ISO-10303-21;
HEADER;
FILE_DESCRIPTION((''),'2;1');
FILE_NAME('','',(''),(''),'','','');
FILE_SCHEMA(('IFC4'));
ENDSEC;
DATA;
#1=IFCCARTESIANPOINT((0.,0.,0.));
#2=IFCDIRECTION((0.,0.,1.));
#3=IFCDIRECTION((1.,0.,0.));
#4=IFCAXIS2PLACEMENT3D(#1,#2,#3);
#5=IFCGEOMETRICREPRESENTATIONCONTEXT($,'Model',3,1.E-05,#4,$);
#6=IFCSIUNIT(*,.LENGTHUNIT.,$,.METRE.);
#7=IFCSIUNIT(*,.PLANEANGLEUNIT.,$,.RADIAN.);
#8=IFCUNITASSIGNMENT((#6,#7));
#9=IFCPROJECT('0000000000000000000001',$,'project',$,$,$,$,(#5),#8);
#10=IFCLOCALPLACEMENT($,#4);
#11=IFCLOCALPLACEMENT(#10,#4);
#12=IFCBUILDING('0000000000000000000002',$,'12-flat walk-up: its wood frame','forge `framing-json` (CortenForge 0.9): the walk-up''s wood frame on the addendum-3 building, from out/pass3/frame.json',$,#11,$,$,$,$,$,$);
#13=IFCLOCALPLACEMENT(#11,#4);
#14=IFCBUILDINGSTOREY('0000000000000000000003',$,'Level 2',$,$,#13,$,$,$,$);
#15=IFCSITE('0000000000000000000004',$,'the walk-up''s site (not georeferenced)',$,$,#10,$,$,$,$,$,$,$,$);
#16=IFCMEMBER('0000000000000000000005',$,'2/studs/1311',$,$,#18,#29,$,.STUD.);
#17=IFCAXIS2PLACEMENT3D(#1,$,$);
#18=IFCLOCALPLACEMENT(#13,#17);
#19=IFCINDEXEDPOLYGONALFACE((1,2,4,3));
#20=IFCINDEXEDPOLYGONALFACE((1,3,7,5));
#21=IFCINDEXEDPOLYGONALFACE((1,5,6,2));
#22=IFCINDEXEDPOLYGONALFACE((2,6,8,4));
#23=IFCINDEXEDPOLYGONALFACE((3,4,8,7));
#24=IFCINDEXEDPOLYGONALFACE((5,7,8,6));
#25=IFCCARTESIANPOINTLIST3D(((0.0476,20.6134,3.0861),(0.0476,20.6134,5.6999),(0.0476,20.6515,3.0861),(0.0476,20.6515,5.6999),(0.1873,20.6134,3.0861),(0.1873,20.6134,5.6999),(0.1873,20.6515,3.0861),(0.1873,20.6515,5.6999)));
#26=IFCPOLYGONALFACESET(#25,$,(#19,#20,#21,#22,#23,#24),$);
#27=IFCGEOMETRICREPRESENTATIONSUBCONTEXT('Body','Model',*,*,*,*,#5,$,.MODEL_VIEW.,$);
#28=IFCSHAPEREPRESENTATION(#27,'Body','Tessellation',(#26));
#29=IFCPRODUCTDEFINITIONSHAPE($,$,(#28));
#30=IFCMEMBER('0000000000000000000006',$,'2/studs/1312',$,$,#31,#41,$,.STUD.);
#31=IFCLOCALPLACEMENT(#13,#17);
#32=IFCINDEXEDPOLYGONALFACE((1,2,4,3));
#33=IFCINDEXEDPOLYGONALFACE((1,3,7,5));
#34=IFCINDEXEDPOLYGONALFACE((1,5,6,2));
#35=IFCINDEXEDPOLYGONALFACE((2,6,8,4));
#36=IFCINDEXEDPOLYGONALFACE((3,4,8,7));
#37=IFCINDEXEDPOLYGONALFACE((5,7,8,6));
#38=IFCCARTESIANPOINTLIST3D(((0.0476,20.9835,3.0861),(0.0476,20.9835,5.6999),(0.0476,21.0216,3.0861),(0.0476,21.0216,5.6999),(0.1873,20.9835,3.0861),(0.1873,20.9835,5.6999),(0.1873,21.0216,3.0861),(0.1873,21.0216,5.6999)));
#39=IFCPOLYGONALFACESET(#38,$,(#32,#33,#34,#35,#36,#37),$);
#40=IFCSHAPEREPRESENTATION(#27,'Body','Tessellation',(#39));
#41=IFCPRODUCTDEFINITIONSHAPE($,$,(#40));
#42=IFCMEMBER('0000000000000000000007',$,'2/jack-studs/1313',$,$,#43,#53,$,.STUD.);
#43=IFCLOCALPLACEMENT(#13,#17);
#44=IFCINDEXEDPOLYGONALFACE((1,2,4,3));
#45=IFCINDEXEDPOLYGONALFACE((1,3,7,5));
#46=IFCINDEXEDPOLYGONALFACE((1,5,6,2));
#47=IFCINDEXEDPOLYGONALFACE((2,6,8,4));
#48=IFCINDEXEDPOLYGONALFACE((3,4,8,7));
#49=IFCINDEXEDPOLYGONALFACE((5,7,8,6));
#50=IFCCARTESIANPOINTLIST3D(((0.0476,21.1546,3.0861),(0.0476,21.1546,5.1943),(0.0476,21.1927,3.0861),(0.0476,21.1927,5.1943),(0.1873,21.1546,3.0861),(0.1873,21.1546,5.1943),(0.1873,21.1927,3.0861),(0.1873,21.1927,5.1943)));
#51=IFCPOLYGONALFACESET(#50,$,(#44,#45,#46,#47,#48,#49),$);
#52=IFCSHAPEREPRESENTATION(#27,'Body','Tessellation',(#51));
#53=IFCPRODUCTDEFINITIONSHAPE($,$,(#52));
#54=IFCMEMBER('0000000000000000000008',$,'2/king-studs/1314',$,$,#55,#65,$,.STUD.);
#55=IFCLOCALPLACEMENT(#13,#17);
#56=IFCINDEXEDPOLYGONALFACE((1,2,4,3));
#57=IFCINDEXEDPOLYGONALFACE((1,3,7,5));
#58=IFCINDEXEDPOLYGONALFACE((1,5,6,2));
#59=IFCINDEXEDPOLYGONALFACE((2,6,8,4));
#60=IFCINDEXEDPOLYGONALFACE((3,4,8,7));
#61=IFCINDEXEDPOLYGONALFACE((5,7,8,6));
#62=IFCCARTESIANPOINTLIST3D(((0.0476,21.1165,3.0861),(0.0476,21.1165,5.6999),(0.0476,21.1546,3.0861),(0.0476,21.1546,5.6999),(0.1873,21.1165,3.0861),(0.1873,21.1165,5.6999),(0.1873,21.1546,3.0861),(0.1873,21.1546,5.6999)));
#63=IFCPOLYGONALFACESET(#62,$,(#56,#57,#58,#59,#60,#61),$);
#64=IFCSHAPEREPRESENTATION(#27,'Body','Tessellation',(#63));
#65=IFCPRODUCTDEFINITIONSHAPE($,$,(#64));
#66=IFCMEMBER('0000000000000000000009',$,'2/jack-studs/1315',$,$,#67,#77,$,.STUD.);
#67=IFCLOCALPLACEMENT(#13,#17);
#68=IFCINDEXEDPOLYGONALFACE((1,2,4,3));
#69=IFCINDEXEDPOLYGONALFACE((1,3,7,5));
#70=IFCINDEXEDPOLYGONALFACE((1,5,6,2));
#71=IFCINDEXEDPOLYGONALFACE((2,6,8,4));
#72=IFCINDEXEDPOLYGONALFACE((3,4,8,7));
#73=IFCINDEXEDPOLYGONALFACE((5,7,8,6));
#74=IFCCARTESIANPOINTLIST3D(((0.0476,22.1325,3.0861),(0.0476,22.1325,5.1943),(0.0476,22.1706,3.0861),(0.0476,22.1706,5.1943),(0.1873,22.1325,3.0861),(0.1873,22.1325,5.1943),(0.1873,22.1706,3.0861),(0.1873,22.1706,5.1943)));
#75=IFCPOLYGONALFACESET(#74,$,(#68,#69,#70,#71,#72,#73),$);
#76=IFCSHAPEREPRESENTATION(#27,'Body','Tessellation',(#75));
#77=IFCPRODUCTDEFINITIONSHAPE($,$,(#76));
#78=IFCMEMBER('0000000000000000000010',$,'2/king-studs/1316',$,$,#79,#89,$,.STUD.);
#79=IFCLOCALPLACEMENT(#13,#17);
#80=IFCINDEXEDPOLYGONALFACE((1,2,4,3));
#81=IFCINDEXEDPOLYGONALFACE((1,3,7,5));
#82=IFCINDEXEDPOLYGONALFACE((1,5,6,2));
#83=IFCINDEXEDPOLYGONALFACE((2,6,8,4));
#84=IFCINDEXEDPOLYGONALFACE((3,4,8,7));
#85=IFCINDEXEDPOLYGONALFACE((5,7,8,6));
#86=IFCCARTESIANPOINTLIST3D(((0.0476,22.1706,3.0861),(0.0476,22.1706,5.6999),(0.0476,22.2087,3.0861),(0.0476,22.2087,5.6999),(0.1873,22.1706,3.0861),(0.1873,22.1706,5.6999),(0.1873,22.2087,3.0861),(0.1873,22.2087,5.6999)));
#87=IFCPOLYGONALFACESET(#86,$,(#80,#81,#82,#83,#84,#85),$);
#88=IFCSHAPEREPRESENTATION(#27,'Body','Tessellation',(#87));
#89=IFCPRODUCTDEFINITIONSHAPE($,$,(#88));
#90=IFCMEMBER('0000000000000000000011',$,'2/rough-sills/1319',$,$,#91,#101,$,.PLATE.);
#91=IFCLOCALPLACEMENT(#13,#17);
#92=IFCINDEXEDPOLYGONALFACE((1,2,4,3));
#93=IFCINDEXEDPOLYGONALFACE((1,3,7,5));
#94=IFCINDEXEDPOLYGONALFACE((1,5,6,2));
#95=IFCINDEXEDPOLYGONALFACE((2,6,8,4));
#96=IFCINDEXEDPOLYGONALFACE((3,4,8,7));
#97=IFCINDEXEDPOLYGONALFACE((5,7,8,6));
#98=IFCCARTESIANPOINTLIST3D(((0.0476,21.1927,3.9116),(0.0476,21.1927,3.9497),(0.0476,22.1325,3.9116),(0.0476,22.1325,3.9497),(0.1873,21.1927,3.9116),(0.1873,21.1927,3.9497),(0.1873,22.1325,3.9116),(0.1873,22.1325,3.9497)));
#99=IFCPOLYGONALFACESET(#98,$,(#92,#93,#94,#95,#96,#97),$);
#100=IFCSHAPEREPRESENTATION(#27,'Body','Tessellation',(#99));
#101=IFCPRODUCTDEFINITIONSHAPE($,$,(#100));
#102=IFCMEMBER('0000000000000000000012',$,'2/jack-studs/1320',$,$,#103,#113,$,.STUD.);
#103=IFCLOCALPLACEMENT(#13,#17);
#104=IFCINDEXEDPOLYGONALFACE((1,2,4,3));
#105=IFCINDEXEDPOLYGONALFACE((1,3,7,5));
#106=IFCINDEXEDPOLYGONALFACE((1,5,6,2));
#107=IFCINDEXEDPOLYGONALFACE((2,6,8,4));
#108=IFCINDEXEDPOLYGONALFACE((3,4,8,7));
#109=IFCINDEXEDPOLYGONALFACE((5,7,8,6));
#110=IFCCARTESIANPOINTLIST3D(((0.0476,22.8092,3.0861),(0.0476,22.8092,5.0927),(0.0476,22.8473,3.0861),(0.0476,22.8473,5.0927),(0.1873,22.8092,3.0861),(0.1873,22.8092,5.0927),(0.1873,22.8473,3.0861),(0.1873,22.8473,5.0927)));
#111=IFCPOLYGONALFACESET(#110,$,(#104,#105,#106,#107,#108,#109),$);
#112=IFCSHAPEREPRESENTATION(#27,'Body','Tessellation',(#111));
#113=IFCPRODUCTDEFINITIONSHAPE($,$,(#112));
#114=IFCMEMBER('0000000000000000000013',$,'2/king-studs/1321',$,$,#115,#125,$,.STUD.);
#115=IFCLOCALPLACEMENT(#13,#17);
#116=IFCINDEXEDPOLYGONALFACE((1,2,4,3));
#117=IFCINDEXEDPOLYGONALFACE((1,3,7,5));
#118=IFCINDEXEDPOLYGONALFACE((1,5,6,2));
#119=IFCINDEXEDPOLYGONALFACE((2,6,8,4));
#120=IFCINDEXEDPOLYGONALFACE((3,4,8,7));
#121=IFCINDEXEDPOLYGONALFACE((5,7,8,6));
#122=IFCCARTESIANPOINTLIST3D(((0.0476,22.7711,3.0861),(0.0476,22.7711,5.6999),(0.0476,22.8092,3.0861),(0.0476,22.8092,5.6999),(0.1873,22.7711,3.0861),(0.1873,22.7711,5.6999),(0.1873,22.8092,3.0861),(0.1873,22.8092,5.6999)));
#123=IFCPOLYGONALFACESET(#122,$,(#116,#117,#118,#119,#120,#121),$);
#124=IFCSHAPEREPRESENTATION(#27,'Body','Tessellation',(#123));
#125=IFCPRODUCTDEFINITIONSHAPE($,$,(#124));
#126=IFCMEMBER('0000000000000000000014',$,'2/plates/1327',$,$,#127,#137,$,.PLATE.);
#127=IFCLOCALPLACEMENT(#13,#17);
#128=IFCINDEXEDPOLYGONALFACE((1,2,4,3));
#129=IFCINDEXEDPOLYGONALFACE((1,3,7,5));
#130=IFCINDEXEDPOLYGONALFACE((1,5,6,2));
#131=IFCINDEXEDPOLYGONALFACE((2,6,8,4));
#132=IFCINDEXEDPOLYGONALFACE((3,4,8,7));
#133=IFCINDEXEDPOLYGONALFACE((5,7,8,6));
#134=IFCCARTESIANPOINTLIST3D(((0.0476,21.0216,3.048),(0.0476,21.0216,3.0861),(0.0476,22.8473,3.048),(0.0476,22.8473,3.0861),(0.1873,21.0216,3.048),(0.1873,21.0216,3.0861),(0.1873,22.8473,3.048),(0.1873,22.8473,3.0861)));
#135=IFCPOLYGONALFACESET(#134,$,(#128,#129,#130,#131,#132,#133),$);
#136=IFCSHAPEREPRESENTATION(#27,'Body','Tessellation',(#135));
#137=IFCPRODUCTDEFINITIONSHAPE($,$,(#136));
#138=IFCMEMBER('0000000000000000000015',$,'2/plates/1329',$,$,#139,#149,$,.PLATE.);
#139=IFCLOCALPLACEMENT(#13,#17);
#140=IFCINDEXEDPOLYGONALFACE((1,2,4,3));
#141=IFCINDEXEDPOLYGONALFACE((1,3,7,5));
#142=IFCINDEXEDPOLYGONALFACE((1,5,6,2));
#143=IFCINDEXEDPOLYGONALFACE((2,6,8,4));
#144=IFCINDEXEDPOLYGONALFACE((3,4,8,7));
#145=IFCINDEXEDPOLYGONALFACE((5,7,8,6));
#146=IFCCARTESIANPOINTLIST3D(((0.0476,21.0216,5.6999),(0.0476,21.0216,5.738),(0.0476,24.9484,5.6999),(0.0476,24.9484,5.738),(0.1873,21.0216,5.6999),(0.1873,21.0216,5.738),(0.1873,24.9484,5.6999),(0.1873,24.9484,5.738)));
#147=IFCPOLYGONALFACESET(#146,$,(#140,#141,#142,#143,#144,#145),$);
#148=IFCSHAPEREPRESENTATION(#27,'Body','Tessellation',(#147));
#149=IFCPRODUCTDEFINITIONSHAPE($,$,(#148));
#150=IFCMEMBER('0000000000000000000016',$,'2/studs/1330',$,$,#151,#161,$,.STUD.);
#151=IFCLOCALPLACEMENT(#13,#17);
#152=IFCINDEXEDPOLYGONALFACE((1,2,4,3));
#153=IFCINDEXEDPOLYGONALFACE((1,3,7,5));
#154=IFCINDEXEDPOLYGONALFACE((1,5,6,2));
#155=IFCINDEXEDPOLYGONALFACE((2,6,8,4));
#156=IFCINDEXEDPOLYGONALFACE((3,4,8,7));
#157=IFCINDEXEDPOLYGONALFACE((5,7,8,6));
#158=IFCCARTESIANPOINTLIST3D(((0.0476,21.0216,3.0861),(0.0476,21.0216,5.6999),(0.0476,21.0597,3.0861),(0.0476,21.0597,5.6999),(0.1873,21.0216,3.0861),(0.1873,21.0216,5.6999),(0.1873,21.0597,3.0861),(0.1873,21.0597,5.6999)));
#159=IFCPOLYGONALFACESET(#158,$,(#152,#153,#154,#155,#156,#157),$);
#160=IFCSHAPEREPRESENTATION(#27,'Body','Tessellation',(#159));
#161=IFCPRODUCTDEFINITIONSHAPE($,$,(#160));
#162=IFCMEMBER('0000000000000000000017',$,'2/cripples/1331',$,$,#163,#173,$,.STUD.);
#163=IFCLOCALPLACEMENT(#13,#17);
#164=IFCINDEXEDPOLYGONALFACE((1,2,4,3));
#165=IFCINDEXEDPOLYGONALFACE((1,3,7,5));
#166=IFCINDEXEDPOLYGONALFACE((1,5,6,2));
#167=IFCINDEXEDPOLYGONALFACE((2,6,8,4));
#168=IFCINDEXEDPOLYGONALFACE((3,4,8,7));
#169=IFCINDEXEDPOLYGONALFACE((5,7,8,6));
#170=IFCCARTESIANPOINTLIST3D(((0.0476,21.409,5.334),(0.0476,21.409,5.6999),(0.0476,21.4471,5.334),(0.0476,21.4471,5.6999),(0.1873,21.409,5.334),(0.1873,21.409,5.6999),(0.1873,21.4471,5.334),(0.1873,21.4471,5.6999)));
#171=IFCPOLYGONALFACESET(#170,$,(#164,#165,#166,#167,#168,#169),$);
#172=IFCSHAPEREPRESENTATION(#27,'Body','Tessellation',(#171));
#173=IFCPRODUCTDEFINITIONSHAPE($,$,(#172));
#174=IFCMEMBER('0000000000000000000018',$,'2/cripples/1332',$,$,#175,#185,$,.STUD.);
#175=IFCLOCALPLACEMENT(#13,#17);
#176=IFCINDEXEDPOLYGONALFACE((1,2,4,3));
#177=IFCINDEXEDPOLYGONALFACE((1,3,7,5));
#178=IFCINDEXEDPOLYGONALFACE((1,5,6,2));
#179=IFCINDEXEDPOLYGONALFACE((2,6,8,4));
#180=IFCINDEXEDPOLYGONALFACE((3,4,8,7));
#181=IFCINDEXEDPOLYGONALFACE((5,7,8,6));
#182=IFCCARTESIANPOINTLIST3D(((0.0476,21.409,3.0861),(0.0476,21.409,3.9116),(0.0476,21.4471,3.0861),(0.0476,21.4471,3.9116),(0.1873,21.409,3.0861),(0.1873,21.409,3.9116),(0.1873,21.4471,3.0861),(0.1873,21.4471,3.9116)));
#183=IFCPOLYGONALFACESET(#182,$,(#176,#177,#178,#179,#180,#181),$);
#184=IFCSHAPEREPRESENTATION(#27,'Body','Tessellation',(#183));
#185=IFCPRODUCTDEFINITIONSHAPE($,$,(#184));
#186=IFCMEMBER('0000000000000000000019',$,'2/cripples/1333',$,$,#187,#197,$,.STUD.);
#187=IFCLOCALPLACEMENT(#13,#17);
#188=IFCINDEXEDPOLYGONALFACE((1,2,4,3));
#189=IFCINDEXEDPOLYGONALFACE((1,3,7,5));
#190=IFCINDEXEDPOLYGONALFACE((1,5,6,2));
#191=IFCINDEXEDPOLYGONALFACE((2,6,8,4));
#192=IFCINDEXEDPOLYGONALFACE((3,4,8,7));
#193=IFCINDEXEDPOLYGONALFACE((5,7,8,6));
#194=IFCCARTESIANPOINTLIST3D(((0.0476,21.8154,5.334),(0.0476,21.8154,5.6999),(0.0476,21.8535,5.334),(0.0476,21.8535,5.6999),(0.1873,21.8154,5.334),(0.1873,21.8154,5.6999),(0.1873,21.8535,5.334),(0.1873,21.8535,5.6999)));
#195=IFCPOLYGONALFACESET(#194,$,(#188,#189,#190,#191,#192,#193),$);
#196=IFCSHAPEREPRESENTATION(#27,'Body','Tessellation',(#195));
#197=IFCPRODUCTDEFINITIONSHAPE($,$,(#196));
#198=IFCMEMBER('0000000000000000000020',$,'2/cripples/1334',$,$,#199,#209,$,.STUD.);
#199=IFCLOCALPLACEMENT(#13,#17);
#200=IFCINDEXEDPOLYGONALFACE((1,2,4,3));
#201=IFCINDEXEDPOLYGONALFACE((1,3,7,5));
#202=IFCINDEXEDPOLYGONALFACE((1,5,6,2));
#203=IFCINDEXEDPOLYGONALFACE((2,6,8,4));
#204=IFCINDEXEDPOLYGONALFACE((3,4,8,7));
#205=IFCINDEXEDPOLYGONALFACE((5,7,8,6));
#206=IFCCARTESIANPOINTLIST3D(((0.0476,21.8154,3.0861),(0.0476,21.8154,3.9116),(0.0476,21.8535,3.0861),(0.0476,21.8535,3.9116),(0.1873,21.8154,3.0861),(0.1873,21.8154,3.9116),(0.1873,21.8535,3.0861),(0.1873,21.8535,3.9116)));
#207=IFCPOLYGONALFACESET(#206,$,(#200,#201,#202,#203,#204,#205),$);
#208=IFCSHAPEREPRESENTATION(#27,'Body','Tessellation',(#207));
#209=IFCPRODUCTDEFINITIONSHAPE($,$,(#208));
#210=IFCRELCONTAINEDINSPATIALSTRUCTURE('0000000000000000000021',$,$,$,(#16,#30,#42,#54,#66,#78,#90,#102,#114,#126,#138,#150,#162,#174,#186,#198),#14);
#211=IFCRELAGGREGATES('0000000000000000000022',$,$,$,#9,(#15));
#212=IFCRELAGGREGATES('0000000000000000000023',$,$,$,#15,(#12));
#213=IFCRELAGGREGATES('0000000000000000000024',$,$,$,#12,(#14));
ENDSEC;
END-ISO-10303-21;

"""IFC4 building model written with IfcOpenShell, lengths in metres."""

from ifc_helpers import new_model, si_unit, frame, frame_2d, origin, origin_with_axes, place, context, subcontext, project, spatial, rectangle, extrude, element, save


model = new_model("IFC4")

# Units and contexts
model_context = context("Model", 3, precision=1e-05, world=origin_with_axes())
body_context = subcontext(model_context, "Body", "Model", "MODEL_VIEW")
ifc_project = project(units=[si_unit("LENGTHUNIT", "METRE"), si_unit("PLANEANGLEUNIT", "RADIAN")], contexts=[model_context])

# Site, building, storey
site_placement = place(None, origin_with_axes())
site = spatial("IfcSite", under=ifc_project, at=site_placement, Name="the walk-up's site (not georeferenced)")
building_placement = place(site_placement, origin_with_axes())
building = spatial("IfcBuilding", under=site, at=building_placement, Name="12-flat walk-up: its wood frame", Description="forge `framing-json` (CortenForge 0.9): the walk-up's wood frame on the addendum-3 building, from out/pass3/frame.json")
storey_placement = place(building_placement, origin_with_axes())
storey = spatial("IfcBuildingStorey", under=building, at=storey_placement, Name="Level 2")

# Members
for number, where, z_axis, x_axis, name in (
    (1, (0.0476, 20.6134, 3.0861), (0.0, 0.0, 1.0), (1.0, 0.0, 0.0), "2/studs/1311"),
    (2, (0.0476, 20.9835, 3.0861), (0.0, 0.0, 1.0), (1.0, 0.0, 0.0), "2/studs/1312"),
):
    element("IfcMember", number, at=place(storey_placement, frame(where, z_axis=z_axis, x_axis=x_axis)), inside=storey, Name=name, PredefinedType="STUD", context=body_context, shape_type="SweptSolid", body=[
        extrude(rectangle(XDim=0.1397, YDim=0.0381, at=frame_2d((0.0698, 0.0191))), origin(), (0.0, 0.0, 1.0), 2.6138),
    ])
member_1_placement = place(storey_placement, frame((0.0476, 21.1546, 3.0861), z_axis=(0.0, 0.0, 1.0), x_axis=(1.0, 0.0, 0.0)))
element("IfcMember", 3, at=member_1_placement, inside=storey, Name="2/jack-studs/1313", PredefinedType="STUD", context=body_context, shape_type="SweptSolid", body=[
    extrude(rectangle(XDim=0.1397, YDim=0.0381, at=frame_2d((0.0698, 0.0191))), origin(), (0.0, 0.0, 1.0), 2.1082),
])
member_2_placement = place(storey_placement, frame((0.0476, 21.1165, 3.0861), z_axis=(0.0, 0.0, 1.0), x_axis=(1.0, 0.0, 0.0)))
element("IfcMember", 4, at=member_2_placement, inside=storey, Name="2/king-studs/1314", PredefinedType="STUD", context=body_context, shape_type="SweptSolid", body=[
    extrude(rectangle(XDim=0.1397, YDim=0.0381, at=frame_2d((0.0698, 0.0191))), origin(), (0.0, 0.0, 1.0), 2.6138),
])
member_3_placement = place(storey_placement, frame((0.0476, 22.1325, 3.0861), z_axis=(0.0, 0.0, 1.0), x_axis=(1.0, 0.0, 0.0)))
element("IfcMember", 5, at=member_3_placement, inside=storey, Name="2/jack-studs/1315", PredefinedType="STUD", context=body_context, shape_type="SweptSolid", body=[
    extrude(rectangle(XDim=0.1397, YDim=0.0381, at=frame_2d((0.0698, 0.0191))), origin(), (0.0, 0.0, 1.0), 2.1082),
])
member_4_placement = place(storey_placement, frame((0.0476, 22.1706, 3.0861), z_axis=(0.0, 0.0, 1.0), x_axis=(1.0, 0.0, 0.0)))
element("IfcMember", 6, at=member_4_placement, inside=storey, Name="2/king-studs/1316", PredefinedType="STUD", context=body_context, shape_type="SweptSolid", body=[
    extrude(rectangle(XDim=0.1397, YDim=0.0381, at=frame_2d((0.0698, 0.0191))), origin(), (0.0, 0.0, 1.0), 2.6138),
])
member_5_placement = place(storey_placement, frame((0.0476, 21.1927, 3.9116), z_axis=(0.0, 0.0, 1.0), x_axis=(1.0, 0.0, 0.0)))
element("IfcMember", 7, at=member_5_placement, inside=storey, Name="2/rough-sills/1319", PredefinedType="PLATE", context=body_context, shape_type="SweptSolid", body=[
    extrude(rectangle(XDim=0.1397, YDim=0.9398, at=frame_2d((0.0698, 0.4699))), origin(), (0.0, 0.0, 1.0), 0.0381),
])
member_6_placement = place(storey_placement, frame((0.0476, 22.8092, 3.0861), z_axis=(0.0, 0.0, 1.0), x_axis=(1.0, 0.0, 0.0)))
element("IfcMember", 8, at=member_6_placement, inside=storey, Name="2/jack-studs/1320", PredefinedType="STUD", context=body_context, shape_type="SweptSolid", body=[
    extrude(rectangle(XDim=0.1397, YDim=0.0381, at=frame_2d((0.0698, 0.0191))), origin(), (0.0, 0.0, 1.0), 2.0066),
])
member_7_placement = place(storey_placement, frame((0.0476, 22.7711, 3.0861), z_axis=(0.0, 0.0, 1.0), x_axis=(1.0, 0.0, 0.0)))
element("IfcMember", 9, at=member_7_placement, inside=storey, Name="2/king-studs/1321", PredefinedType="STUD", context=body_context, shape_type="SweptSolid", body=[
    extrude(rectangle(XDim=0.1397, YDim=0.0381, at=frame_2d((0.0698, 0.0191))), origin(), (0.0, 0.0, 1.0), 2.6138),
])
member_8_placement = place(storey_placement, frame((0.0476, 21.0216, 3.048), z_axis=(0.0, 0.0, 1.0), x_axis=(1.0, 0.0, 0.0)))
element("IfcMember", 10, at=member_8_placement, inside=storey, Name="2/plates/1327", PredefinedType="PLATE", context=body_context, shape_type="SweptSolid", body=[
    extrude(rectangle(XDim=0.1397, YDim=1.8257, at=frame_2d((0.0698, 0.9128))), origin(), (0.0, 0.0, 1.0), 0.0381),
])
member_9_placement = place(storey_placement, frame((0.0476, 21.0216, 5.6999), z_axis=(0.0, 0.0, 1.0), x_axis=(1.0, 0.0, 0.0)))
element("IfcMember", 11, at=member_9_placement, inside=storey, Name="2/plates/1329", PredefinedType="PLATE", context=body_context, shape_type="SweptSolid", body=[
    extrude(rectangle(XDim=0.1397, YDim=3.9268, at=frame_2d((0.0698, 1.9634))), origin(), (0.0, 0.0, 1.0), 0.0381),
])
member_10_placement = place(storey_placement, frame((0.0476, 21.0216, 3.0861), z_axis=(0.0, 0.0, 1.0), x_axis=(1.0, 0.0, 0.0)))
element("IfcMember", 12, at=member_10_placement, inside=storey, Name="2/studs/1330", PredefinedType="STUD", context=body_context, shape_type="SweptSolid", body=[
    extrude(rectangle(XDim=0.1397, YDim=0.0381, at=frame_2d((0.0698, 0.0191))), origin(), (0.0, 0.0, 1.0), 2.6138),
])
member_11_placement = place(storey_placement, frame((0.0476, 21.409, 5.334), z_axis=(0.0, 0.0, 1.0), x_axis=(1.0, 0.0, 0.0)))
element("IfcMember", 13, at=member_11_placement, inside=storey, Name="2/cripples/1331", PredefinedType="STUD", context=body_context, shape_type="SweptSolid", body=[
    extrude(rectangle(XDim=0.1397, YDim=0.0381, at=frame_2d((0.0698, 0.0191))), origin(), (0.0, 0.0, 1.0), 0.3659),
])
member_12_placement = place(storey_placement, frame((0.0476, 21.409, 3.0861), z_axis=(0.0, 0.0, 1.0), x_axis=(1.0, 0.0, 0.0)))
element("IfcMember", 14, at=member_12_placement, inside=storey, Name="2/cripples/1332", PredefinedType="STUD", context=body_context, shape_type="SweptSolid", body=[
    extrude(rectangle(XDim=0.1397, YDim=0.0381, at=frame_2d((0.0698, 0.0191))), origin(), (0.0, 0.0, 1.0), 0.8255),
])
member_13_placement = place(storey_placement, frame((0.0476, 21.8154, 5.334), z_axis=(0.0, 0.0, 1.0), x_axis=(1.0, 0.0, 0.0)))
element("IfcMember", 15, at=member_13_placement, inside=storey, Name="2/cripples/1333", PredefinedType="STUD", context=body_context, shape_type="SweptSolid", body=[
    extrude(rectangle(XDim=0.1397, YDim=0.0381, at=frame_2d((0.0698, 0.0191))), origin(), (0.0, 0.0, 1.0), 0.3659),
])
member_14_placement = place(storey_placement, frame((0.0476, 21.8154, 3.0861), z_axis=(0.0, 0.0, 1.0), x_axis=(1.0, 0.0, 0.0)))
element("IfcMember", 16, at=member_14_placement, inside=storey, Name="2/cripples/1334", PredefinedType="STUD", context=body_context, shape_type="SweptSolid", body=[
    extrude(rectangle(XDim=0.1397, YDim=0.0381, at=frame_2d((0.0698, 0.0191))), origin(), (0.0, 0.0, 1.0), 0.8255),
])

save(model, "model.ifc")
